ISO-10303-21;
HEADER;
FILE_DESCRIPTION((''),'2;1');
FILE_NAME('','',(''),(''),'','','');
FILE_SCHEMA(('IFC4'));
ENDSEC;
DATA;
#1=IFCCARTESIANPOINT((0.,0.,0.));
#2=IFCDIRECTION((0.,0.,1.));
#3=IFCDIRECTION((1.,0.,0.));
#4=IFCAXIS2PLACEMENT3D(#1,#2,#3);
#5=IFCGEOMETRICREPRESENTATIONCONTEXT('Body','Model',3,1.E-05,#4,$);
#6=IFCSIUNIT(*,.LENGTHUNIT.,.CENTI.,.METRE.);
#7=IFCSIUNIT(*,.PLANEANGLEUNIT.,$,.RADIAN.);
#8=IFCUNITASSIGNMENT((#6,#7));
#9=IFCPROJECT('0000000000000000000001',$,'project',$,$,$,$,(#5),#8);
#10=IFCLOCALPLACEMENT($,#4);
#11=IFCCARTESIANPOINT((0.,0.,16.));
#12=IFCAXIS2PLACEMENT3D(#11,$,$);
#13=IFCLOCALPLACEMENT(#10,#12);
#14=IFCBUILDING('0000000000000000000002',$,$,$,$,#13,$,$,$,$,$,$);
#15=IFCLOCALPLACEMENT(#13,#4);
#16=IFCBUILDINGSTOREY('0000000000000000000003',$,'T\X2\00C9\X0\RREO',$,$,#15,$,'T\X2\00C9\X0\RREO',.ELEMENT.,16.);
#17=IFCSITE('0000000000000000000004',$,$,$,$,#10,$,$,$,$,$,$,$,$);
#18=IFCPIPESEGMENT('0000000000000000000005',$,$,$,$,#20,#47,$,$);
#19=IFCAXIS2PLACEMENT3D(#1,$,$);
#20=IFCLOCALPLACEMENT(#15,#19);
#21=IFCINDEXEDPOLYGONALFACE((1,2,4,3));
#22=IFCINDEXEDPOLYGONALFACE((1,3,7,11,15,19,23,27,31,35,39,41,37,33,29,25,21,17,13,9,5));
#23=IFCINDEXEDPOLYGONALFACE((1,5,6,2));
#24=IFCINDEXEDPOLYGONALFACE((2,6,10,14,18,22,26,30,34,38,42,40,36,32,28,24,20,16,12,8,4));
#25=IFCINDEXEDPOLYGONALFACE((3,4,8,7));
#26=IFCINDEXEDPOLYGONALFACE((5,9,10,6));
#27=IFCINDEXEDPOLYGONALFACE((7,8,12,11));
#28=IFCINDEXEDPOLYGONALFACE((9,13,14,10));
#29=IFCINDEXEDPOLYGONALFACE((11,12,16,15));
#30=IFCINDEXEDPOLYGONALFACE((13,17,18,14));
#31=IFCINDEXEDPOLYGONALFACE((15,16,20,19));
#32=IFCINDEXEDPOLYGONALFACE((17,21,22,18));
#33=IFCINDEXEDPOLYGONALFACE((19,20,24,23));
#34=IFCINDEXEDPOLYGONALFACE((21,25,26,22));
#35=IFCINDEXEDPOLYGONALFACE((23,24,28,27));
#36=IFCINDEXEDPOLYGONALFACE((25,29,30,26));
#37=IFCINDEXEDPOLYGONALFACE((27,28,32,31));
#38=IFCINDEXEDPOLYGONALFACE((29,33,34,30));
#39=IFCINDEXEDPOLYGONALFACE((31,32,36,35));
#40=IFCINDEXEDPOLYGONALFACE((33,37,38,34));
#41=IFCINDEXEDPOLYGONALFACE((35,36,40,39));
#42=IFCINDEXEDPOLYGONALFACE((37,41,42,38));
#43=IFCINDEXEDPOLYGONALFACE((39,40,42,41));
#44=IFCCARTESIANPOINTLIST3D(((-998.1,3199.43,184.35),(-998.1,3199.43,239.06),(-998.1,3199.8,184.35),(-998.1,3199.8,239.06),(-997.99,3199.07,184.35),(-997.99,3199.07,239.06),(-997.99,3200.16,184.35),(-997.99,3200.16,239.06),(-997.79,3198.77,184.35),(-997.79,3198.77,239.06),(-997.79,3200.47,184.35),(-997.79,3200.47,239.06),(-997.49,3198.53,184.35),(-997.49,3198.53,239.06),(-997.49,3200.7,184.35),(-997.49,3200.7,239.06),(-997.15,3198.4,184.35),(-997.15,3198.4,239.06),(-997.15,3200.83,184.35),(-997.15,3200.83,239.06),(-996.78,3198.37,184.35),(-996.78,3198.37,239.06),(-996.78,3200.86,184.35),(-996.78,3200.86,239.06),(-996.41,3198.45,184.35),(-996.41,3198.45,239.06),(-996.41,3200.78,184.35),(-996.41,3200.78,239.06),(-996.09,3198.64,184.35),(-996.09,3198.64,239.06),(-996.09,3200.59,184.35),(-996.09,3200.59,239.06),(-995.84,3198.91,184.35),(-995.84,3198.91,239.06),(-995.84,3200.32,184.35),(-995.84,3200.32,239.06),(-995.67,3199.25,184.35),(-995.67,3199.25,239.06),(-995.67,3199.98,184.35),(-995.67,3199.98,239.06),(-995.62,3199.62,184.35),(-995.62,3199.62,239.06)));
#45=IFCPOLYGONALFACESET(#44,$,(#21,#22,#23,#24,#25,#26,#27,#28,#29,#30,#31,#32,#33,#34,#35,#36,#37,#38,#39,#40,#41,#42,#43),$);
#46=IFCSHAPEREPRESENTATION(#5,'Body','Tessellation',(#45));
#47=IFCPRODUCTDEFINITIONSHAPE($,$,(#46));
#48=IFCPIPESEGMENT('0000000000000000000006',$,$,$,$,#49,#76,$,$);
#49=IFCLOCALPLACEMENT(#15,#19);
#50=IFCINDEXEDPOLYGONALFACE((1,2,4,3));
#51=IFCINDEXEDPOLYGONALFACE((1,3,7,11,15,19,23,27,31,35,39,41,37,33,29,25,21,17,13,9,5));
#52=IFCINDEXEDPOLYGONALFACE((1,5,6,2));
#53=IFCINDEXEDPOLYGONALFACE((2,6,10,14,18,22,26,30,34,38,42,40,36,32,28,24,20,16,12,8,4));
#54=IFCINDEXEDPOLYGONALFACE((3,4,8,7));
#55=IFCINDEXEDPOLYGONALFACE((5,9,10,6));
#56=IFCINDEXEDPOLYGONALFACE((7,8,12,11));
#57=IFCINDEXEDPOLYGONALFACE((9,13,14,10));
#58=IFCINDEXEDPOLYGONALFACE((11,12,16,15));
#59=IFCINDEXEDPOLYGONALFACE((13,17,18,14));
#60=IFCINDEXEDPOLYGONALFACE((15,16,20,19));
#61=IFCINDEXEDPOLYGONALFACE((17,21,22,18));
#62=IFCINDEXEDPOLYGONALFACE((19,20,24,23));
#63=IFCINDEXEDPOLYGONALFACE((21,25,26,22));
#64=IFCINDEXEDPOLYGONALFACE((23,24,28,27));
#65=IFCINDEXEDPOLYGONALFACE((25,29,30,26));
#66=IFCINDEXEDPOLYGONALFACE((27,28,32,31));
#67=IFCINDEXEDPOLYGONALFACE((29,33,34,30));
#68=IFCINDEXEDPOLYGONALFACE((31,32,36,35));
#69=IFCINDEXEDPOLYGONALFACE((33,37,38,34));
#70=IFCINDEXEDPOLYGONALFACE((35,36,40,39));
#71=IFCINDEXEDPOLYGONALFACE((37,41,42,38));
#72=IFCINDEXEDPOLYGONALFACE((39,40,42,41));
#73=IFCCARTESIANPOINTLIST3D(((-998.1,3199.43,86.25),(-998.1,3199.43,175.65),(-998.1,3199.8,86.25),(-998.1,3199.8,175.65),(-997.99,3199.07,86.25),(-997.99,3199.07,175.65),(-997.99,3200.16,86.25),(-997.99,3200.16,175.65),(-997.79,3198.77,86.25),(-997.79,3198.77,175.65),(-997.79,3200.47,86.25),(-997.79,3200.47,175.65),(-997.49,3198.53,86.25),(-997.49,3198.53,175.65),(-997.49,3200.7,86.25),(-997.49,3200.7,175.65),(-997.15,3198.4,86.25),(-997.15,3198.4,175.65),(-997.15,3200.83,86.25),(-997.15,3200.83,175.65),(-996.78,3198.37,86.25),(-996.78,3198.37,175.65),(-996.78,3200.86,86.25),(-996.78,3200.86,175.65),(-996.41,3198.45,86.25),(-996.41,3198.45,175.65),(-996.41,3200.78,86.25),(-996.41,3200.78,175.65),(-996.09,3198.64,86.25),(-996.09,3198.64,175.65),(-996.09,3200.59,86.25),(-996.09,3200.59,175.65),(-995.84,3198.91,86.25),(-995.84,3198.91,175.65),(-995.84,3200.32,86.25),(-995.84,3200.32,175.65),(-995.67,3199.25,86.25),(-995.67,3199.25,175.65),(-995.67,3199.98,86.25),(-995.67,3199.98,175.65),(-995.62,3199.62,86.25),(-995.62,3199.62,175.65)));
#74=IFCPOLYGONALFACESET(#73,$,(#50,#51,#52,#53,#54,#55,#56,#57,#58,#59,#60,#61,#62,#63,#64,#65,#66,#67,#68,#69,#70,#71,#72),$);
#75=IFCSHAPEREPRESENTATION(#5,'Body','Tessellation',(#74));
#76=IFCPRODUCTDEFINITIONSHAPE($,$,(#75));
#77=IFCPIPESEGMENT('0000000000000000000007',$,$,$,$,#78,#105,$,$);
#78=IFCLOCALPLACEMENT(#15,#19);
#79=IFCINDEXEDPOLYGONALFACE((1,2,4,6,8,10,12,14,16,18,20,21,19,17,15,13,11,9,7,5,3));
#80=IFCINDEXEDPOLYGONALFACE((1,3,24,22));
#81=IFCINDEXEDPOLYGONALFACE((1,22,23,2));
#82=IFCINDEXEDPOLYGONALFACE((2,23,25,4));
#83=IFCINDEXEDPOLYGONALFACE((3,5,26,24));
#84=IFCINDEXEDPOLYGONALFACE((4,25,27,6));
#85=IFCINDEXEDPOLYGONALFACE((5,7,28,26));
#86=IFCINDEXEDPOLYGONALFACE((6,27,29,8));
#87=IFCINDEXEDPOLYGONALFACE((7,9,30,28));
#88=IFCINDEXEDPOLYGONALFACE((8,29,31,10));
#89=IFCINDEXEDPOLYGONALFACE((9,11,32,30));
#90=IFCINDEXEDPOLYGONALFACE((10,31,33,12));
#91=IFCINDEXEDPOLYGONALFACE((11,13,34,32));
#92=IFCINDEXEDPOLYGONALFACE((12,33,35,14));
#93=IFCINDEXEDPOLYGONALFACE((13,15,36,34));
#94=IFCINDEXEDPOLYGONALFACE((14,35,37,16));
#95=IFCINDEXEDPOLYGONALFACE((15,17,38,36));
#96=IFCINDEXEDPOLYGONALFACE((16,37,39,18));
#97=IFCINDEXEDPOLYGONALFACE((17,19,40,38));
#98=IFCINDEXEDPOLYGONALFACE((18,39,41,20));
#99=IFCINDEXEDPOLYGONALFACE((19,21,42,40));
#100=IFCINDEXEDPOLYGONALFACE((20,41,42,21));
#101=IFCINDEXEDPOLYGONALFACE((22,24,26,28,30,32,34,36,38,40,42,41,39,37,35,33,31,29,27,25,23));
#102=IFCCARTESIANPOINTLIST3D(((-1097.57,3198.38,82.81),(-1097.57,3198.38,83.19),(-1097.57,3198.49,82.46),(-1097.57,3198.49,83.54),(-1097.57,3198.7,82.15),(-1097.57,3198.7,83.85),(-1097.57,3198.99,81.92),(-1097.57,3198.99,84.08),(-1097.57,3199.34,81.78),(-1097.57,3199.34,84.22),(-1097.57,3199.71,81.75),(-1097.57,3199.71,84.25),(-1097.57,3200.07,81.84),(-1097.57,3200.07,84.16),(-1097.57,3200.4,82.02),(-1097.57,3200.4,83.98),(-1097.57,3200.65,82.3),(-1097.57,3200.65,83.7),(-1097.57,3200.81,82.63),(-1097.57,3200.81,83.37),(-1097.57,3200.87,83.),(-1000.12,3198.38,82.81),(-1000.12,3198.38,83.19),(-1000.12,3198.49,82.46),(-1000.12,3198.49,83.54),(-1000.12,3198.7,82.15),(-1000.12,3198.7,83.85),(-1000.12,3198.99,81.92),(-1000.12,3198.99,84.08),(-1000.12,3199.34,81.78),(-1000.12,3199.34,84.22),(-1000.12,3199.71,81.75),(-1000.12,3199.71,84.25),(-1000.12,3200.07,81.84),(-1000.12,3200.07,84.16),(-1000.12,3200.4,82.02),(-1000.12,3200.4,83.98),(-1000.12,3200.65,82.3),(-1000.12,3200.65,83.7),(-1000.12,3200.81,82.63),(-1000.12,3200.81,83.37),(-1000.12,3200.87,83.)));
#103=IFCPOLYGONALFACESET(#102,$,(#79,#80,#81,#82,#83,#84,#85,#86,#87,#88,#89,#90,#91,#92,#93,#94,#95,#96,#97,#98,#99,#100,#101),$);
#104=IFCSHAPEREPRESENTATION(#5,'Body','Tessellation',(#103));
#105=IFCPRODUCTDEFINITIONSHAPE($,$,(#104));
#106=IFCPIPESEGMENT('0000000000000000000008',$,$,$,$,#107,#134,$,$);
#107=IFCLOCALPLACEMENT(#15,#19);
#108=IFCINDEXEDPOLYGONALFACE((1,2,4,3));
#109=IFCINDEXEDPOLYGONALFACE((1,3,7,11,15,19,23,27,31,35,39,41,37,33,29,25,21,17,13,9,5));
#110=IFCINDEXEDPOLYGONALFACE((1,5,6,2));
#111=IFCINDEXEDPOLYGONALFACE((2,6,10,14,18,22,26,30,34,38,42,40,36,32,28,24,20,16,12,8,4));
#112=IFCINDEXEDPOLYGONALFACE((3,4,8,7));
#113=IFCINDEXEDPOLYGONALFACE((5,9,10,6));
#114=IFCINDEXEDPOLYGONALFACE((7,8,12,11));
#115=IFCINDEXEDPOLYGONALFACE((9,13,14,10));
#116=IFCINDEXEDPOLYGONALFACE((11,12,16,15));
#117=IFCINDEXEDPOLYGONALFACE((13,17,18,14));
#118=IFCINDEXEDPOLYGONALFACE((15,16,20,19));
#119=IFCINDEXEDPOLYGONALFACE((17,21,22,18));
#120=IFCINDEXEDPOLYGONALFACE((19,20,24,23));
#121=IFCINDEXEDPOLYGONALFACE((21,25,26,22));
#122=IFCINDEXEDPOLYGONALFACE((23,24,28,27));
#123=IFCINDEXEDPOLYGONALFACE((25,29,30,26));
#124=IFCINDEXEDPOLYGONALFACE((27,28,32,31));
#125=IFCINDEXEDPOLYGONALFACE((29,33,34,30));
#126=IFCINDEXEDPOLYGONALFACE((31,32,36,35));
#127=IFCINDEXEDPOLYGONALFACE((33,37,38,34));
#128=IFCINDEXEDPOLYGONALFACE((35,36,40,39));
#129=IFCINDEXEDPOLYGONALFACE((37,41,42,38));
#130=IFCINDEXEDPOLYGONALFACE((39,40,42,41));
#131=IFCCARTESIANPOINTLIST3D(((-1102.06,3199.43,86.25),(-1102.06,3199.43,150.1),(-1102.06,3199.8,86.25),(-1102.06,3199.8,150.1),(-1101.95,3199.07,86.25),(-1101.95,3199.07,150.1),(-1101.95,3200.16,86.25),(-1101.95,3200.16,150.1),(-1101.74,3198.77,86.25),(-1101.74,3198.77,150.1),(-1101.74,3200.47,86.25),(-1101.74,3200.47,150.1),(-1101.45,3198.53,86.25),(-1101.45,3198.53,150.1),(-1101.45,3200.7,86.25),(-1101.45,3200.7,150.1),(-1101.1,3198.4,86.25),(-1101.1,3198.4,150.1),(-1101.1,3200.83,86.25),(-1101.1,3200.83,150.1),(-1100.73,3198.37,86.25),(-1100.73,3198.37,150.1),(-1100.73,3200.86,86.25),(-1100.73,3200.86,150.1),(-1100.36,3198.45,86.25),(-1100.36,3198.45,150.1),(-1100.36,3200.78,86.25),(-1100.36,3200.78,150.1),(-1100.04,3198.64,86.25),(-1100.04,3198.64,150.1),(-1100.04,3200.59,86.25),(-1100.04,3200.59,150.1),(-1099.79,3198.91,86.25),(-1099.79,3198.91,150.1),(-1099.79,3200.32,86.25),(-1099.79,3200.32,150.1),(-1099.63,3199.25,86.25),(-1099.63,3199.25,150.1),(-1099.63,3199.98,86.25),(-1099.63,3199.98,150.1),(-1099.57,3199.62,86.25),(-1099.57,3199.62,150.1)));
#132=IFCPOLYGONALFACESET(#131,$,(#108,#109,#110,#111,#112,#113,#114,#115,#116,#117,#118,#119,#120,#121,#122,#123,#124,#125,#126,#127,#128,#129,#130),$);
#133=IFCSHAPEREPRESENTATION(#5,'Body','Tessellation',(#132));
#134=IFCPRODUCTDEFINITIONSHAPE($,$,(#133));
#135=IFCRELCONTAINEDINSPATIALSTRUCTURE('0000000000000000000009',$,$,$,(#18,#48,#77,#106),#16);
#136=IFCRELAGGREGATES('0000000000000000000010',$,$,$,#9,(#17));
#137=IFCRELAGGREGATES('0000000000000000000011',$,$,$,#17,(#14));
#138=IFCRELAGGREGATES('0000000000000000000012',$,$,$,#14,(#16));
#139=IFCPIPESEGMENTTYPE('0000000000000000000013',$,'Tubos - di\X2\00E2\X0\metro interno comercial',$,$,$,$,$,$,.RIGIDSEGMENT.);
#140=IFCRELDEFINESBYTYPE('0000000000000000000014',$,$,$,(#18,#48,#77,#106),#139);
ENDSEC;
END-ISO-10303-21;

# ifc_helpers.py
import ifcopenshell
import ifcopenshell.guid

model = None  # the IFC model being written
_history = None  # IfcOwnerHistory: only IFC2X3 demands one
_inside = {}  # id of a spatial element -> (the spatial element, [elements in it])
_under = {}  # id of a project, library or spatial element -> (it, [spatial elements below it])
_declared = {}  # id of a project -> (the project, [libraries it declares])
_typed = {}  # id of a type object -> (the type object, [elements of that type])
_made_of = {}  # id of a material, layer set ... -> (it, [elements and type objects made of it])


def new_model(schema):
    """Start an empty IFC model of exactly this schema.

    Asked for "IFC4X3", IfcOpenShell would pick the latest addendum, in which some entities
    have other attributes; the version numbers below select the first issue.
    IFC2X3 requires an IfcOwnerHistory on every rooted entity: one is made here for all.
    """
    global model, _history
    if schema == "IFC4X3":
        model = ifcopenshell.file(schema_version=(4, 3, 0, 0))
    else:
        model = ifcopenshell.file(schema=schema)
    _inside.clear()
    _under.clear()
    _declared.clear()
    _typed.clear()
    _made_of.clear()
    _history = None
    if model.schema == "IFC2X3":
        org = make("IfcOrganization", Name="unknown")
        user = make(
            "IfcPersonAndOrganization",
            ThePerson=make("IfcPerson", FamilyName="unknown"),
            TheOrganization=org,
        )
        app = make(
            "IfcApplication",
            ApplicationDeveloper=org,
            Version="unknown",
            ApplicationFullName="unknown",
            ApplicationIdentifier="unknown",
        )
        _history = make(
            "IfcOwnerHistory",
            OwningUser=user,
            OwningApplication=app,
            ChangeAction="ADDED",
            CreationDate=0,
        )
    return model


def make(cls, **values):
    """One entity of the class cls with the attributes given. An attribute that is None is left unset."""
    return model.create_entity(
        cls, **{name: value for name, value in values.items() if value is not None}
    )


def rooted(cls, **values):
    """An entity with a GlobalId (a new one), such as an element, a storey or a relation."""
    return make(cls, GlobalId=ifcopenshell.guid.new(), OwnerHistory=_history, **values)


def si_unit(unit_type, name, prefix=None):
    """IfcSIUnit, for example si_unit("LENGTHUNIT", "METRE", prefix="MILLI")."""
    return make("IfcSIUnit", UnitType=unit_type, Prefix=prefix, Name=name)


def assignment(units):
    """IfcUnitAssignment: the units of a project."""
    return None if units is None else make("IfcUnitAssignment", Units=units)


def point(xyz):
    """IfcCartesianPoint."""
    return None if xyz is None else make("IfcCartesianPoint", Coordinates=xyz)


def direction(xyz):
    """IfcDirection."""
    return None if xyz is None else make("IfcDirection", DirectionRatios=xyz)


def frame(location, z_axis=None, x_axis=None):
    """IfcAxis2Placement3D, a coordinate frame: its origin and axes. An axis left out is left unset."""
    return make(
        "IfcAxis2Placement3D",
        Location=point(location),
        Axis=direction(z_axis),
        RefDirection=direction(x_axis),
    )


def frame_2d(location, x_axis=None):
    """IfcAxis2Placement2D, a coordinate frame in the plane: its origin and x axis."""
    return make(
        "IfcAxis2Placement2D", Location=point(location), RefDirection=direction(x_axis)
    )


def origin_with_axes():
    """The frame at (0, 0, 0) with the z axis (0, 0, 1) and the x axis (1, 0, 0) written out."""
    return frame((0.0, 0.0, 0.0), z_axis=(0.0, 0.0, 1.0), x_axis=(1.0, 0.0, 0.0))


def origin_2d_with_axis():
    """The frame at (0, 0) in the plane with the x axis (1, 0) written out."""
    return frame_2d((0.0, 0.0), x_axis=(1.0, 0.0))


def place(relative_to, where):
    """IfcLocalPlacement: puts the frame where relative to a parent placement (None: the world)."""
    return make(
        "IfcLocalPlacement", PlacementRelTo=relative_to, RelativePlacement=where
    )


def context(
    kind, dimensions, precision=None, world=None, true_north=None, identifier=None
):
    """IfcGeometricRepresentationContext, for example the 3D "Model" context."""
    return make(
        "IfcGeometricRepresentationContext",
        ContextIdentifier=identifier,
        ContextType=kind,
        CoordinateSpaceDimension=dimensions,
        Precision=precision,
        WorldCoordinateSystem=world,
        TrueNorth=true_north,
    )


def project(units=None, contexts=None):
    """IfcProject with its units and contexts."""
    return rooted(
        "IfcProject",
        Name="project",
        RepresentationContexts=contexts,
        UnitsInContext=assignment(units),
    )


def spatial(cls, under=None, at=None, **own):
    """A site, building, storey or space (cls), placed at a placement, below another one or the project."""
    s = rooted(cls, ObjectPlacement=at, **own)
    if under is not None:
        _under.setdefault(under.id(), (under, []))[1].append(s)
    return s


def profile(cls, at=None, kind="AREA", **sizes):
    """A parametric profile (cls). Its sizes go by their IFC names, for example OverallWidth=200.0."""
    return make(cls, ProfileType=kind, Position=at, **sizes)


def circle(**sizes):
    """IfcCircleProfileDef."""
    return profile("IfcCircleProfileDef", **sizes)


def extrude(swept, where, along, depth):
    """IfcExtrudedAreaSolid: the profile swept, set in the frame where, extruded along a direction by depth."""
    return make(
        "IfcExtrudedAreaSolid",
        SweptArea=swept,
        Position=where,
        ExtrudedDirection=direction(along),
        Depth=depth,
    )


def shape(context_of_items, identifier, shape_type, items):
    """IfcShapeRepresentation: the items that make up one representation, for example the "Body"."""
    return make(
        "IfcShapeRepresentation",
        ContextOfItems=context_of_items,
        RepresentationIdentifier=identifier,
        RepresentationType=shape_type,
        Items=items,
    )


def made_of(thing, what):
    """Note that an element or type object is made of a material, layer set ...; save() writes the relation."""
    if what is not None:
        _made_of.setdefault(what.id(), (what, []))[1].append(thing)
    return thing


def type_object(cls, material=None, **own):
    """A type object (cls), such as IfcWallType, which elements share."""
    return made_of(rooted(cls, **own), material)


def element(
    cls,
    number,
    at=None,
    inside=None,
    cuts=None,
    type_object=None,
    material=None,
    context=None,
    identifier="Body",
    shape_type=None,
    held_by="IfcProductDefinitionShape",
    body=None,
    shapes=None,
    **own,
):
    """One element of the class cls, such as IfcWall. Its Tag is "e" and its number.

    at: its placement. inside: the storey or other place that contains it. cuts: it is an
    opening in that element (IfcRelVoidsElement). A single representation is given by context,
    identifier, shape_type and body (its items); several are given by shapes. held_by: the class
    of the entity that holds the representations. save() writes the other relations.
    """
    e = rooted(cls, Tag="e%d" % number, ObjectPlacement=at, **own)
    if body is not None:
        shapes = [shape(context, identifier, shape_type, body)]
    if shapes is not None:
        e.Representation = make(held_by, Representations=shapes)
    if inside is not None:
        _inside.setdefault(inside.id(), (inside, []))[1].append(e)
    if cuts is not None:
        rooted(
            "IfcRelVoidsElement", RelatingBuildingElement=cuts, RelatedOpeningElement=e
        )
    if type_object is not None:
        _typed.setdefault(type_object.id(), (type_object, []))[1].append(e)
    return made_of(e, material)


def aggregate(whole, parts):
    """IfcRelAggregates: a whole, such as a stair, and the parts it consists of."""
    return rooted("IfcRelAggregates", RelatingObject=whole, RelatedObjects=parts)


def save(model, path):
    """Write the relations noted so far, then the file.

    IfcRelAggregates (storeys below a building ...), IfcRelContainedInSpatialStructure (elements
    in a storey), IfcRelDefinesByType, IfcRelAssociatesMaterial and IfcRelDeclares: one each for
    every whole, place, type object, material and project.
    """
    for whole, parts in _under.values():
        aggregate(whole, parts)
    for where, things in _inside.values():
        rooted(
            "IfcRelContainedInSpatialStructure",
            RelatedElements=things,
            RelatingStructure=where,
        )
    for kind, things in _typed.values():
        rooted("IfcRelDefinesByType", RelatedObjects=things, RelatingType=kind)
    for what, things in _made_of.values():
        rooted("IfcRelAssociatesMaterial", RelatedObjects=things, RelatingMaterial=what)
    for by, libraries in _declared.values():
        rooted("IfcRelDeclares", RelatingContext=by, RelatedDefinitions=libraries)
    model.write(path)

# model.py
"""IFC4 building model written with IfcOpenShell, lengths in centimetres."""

from ifc_helpers import new_model, si_unit, frame, origin_with_axes, origin_2d_with_axis, place, context, project, spatial, circle, extrude, type_object, element, save


model = new_model("IFC4")

# Units and contexts
model_context = context("Model", 3, precision=1e-05, world=origin_with_axes(), identifier="Body")
ifc_project = project(units=[si_unit("LENGTHUNIT", "METRE", prefix="CENTI"), si_unit("PLANEANGLEUNIT", "RADIAN")], contexts=[model_context])

# Site, building, storey
site_placement = place(None, origin_with_axes())
site = spatial("IfcSite", under=ifc_project, at=site_placement)
building_placement = place(site_placement, frame((0.0, 0.0, 16.0)))
building = spatial("IfcBuilding", under=site, at=building_placement)
storey_placement = place(building_placement, origin_with_axes())
storey = spatial("IfcBuildingStorey", under=building, at=storey_placement, Name="TÉRREO", LongName="TÉRREO", CompositionType="ELEMENT", Elevation=16.0)

# Pipe segments
pipe_segment_type = type_object("IfcPipeSegmentType", Name="Tubos - diâmetro interno comercial", PredefinedType="RIGIDSEGMENT")
pipe_segment_1_placement = place(storey_placement, frame((-996.87, 3199.62, 239.06), z_axis=(0.0, 0.0, 1.0), x_axis=(1.0, 0.0, 0.0)))
element("IfcPipeSegment", 1, at=pipe_segment_1_placement, inside=storey, type_object=pipe_segment_type, context=model_context, shape_type="SolidModel", body=[
    extrude(circle(Radius=1.25, at=origin_2d_with_axis()), frame((0.0, 0.0, 0.0), z_axis=(0.0, 0.0, -1.0), x_axis=(1.0, 0.0, 0.0)), (0.0, 0.0, 1.0), 54.71),
])
pipe_segment_2_placement = place(storey_placement, frame((-996.87, 3199.62, 175.65), z_axis=(0.0, 0.0, 1.0), x_axis=(1.0, 0.0, 0.0)))
element("IfcPipeSegment", 2, at=pipe_segment_2_placement, inside=storey, type_object=pipe_segment_type, context=model_context, shape_type="SolidModel", body=[
    extrude(circle(Radius=1.25, at=origin_2d_with_axis()), frame((0.0, 0.0, 0.0), z_axis=(0.0, 0.0, -1.0), x_axis=(1.0, 0.0, 0.0)), (0.0, 0.0, 1.0), 89.4),
])
pipe_segment_3_placement = place(storey_placement, frame((-1048.84, 3199.62, 84.25), z_axis=(0.0, 0.0, 1.0), x_axis=(1.0, 0.0, 0.0)))
element("IfcPipeSegment", 3, at=pipe_segment_3_placement, inside=storey, type_object=pipe_segment_type, context=model_context, shape_type="SolidModel", body=[
    extrude(circle(Radius=1.25, at=origin_2d_with_axis()), frame((48.73, 0.0, -1.25), z_axis=(-1.0, 0.0, 0.0), x_axis=(0.0, 1.0, 0.0)), (0.0, 0.0, 1.0), 97.45),
])
pipe_segment_4_placement = place(storey_placement, frame((-1100.82, 3199.62, 150.1), z_axis=(0.0, 0.0, 1.0), x_axis=(1.0, 0.0, 0.0)))
element("IfcPipeSegment", 4, at=pipe_segment_4_placement, inside=storey, type_object=pipe_segment_type, context=model_context, shape_type="SolidModel", body=[
    extrude(circle(Radius=1.25, at=origin_2d_with_axis()), frame((0.0, 0.0, -63.85), z_axis=(0.0, 0.0, 1.0), x_axis=(1.0, 0.0, 0.0)), (0.0, 0.0, 1.0), 63.85),
])

save(model, "model.ifc")
